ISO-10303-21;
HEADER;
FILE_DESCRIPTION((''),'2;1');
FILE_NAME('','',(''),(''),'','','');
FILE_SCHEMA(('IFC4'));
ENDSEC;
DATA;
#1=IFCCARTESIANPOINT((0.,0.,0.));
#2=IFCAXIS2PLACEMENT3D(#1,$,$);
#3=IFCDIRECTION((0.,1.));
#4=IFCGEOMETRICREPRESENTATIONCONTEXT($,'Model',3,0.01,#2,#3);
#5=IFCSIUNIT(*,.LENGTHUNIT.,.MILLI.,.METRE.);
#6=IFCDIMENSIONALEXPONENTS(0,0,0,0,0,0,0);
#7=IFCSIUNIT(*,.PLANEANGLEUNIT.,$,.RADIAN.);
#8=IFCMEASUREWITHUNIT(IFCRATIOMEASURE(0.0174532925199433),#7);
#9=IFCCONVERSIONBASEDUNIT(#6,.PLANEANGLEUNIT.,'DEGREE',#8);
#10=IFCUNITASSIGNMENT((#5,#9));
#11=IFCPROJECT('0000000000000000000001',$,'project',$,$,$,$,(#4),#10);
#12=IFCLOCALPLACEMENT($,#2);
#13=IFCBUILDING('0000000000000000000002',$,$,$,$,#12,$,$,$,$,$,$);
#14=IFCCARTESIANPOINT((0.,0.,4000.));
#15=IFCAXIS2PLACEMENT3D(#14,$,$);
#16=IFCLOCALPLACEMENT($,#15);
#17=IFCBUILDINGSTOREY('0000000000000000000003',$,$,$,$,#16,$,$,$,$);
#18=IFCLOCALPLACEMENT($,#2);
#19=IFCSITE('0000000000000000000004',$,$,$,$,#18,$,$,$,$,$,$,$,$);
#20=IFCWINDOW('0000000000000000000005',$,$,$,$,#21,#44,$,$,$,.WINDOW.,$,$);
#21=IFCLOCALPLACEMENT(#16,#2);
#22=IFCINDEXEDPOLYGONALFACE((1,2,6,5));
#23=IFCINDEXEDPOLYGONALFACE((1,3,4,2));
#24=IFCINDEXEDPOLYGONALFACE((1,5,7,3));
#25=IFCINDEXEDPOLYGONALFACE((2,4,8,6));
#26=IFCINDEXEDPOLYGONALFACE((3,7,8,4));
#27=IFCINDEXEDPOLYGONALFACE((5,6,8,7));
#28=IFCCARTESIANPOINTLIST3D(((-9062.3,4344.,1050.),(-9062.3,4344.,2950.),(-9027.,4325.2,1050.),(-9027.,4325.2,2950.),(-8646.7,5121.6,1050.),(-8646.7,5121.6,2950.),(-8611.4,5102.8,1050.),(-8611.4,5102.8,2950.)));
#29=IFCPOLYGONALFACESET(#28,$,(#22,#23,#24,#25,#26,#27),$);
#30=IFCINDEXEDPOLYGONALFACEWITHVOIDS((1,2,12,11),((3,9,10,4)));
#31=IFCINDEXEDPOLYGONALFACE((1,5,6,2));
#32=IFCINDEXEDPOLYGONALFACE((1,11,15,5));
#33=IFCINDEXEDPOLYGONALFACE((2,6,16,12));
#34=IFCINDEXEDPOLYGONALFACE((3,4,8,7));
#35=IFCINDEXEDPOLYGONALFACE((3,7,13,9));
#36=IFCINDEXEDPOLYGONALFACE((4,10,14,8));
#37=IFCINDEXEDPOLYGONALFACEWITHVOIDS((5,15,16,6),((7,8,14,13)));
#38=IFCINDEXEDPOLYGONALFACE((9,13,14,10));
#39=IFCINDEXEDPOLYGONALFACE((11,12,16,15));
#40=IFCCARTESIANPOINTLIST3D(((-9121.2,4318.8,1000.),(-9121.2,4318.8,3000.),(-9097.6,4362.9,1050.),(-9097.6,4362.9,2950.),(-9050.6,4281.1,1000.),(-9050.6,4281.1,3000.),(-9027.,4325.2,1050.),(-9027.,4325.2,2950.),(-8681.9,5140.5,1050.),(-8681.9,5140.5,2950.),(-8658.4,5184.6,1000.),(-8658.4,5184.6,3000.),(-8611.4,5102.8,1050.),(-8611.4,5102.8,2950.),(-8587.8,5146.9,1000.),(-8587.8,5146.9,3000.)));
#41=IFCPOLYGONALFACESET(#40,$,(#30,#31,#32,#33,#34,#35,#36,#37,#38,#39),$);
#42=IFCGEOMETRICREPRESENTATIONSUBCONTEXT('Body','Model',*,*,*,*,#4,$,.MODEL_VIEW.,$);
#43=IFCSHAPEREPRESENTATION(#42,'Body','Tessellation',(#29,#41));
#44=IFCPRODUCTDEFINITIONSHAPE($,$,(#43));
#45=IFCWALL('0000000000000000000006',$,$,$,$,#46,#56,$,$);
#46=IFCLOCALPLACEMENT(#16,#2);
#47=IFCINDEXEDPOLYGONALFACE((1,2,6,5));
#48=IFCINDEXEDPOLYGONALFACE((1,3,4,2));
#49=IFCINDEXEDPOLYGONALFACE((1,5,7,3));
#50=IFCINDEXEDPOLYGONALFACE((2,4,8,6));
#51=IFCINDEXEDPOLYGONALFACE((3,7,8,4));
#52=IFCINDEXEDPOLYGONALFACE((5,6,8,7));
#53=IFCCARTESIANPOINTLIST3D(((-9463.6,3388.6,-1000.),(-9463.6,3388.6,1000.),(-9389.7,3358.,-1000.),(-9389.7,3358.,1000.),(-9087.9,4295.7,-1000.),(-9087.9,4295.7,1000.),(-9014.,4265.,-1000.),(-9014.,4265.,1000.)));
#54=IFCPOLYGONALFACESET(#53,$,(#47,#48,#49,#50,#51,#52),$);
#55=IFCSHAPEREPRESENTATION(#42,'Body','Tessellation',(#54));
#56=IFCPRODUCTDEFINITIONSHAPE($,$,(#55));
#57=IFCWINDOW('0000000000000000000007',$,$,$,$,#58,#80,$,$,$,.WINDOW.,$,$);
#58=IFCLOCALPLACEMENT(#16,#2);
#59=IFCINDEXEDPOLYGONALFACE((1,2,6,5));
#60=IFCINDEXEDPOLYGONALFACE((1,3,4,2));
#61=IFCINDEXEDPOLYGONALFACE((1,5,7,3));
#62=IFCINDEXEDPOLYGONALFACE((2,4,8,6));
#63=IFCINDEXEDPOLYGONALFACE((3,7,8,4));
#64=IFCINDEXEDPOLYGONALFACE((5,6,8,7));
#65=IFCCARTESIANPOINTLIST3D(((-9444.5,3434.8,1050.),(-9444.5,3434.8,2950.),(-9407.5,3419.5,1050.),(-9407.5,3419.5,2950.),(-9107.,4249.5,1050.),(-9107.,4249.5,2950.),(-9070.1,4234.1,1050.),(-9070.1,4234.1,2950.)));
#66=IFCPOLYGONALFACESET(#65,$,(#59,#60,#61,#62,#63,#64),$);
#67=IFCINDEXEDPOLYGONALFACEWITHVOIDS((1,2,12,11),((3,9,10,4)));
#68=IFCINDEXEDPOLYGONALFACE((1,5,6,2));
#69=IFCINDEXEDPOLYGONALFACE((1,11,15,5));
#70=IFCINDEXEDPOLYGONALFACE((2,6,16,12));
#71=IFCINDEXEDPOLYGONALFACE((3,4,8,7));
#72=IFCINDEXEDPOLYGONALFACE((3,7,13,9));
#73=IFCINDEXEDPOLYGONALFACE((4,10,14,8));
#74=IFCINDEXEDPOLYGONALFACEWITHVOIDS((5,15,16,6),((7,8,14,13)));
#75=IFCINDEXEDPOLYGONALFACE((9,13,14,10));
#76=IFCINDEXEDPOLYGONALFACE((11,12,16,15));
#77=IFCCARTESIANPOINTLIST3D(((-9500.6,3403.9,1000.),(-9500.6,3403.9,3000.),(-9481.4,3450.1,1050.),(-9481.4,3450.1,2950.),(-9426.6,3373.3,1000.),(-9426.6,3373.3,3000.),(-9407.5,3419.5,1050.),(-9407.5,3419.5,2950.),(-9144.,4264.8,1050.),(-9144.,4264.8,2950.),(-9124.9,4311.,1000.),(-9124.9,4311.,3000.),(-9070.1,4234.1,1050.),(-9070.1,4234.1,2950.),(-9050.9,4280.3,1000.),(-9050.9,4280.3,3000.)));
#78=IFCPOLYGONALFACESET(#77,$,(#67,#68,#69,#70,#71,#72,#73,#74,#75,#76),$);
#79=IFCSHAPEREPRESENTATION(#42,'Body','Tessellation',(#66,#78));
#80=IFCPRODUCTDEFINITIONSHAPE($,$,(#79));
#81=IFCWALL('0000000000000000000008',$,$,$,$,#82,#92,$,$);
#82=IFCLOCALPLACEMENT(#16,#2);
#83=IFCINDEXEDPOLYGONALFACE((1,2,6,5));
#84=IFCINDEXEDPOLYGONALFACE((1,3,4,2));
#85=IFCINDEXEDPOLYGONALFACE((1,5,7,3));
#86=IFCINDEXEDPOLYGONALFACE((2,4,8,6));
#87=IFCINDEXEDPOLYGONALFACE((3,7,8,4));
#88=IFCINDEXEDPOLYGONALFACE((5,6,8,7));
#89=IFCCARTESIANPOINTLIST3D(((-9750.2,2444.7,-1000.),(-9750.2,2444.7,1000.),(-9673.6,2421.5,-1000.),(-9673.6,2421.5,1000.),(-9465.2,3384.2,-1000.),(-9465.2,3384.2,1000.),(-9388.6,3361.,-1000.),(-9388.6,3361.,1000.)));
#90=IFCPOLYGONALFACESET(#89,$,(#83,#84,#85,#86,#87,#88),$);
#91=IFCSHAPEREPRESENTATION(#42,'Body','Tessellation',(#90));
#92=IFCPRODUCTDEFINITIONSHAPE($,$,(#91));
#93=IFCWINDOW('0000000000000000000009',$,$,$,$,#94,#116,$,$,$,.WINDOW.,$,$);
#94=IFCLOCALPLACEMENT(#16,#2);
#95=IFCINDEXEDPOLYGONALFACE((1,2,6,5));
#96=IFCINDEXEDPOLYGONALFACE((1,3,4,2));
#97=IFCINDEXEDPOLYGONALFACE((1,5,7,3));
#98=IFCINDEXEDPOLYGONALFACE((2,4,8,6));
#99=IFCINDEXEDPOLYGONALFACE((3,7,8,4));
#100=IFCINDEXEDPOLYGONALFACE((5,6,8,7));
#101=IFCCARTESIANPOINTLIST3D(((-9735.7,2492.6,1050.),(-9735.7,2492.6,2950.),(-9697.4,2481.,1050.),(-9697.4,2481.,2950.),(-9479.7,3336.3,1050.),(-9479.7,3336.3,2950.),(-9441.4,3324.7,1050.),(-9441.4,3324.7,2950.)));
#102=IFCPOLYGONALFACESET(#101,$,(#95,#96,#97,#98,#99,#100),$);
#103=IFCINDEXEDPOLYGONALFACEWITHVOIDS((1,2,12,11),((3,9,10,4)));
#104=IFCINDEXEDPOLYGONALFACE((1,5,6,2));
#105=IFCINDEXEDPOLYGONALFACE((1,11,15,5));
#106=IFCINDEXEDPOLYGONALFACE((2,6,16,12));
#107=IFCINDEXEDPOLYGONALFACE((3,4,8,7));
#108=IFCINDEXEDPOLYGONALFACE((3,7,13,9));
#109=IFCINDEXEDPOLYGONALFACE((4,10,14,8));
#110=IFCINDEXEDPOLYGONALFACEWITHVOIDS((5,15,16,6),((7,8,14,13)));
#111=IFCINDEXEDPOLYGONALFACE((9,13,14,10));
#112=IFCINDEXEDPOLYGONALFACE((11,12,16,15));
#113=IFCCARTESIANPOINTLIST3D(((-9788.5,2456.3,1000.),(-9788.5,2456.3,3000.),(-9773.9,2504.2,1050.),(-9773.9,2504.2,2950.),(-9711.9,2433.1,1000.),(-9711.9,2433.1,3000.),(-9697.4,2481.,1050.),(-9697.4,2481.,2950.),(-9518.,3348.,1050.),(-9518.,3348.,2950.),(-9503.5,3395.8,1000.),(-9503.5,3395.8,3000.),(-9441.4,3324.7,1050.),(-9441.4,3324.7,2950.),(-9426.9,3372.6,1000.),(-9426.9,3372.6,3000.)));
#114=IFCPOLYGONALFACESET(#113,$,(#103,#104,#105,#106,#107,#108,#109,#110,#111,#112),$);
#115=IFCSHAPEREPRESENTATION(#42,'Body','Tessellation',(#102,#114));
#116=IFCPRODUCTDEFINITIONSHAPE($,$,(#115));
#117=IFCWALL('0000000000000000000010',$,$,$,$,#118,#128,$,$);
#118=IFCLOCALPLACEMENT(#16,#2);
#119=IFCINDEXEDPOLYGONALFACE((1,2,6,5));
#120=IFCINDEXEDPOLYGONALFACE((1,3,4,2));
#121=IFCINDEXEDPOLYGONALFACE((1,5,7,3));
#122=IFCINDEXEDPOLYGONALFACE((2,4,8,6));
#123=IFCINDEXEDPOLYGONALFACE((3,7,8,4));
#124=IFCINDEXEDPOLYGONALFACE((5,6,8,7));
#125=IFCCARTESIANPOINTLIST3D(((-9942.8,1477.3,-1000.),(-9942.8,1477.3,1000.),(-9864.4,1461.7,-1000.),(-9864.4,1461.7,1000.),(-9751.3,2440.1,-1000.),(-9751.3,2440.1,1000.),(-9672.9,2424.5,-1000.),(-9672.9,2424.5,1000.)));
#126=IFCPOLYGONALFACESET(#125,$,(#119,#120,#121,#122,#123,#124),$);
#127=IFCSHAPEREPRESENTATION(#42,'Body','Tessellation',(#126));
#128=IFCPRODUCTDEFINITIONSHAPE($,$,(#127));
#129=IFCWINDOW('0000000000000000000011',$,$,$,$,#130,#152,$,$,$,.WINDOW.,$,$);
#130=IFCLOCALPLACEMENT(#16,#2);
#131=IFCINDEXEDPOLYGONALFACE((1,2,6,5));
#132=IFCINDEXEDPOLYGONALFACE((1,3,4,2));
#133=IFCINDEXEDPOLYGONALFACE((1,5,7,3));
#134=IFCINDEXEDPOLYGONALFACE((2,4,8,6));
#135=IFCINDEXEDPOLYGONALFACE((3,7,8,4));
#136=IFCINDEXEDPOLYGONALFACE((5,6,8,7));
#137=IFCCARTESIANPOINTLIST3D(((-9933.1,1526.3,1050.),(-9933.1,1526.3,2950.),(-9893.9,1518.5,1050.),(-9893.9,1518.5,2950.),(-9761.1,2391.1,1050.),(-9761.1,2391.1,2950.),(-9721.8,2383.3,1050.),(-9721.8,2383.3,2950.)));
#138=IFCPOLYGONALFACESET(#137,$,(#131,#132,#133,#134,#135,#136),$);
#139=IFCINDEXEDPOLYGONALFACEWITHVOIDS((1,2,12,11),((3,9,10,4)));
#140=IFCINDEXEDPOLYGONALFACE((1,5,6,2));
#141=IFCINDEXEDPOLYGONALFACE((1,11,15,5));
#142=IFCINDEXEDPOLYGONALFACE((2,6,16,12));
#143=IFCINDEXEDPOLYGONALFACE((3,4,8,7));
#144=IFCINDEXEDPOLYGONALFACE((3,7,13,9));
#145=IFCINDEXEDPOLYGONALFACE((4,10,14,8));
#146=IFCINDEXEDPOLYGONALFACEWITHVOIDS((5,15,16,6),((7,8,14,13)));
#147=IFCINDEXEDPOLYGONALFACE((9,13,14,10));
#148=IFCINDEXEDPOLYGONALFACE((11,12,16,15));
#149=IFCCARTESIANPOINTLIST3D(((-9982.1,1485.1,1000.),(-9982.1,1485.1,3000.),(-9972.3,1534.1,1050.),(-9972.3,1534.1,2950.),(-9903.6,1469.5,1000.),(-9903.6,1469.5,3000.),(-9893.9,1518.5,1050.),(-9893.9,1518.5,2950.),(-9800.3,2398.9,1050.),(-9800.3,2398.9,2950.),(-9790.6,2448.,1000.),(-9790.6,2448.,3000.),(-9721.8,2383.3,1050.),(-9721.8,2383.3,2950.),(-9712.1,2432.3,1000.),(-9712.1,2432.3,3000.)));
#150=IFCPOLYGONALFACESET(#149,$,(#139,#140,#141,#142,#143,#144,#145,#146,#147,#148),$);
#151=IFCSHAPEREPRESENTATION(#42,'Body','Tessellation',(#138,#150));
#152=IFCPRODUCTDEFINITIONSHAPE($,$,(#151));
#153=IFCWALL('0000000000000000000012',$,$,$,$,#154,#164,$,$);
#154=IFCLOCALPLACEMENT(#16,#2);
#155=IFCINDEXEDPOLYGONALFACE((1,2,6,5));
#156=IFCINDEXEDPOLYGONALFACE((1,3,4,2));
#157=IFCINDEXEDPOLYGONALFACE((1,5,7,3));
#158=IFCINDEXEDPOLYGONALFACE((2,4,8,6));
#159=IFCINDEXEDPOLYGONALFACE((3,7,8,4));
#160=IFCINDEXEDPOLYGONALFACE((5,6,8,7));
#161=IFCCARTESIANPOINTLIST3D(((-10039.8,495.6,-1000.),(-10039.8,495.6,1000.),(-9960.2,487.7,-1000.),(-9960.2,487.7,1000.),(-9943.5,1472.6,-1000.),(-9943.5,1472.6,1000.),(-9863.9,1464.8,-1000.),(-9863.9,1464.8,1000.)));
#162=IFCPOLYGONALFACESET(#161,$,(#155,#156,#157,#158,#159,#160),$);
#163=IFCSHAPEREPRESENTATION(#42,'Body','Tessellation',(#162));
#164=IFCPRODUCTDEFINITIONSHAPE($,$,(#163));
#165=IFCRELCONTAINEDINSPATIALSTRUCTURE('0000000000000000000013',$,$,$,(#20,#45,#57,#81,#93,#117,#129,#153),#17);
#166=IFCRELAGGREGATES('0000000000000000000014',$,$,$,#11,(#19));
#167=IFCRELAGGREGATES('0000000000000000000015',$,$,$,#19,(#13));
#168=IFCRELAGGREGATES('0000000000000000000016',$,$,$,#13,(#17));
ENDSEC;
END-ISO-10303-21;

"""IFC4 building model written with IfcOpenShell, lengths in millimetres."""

from ifc_helpers import new_model, entity, si_unit, converted_unit, direction, frame, origin, origin_2d, place, context, subcontext, project, spatial, rectangle, extrude, element, save


model = new_model("IFC4")

# Units and contexts
model_context = context("Model", 3, precision=0.01, world=origin(), true_north=direction((0.0, 1.0)))
body_context = subcontext(model_context, "Body", "Model", "MODEL_VIEW")
ifc_project = project(units=[si_unit("LENGTHUNIT", "METRE", prefix="MILLI"), converted_unit("PLANEANGLEUNIT", "DEGREE", entity("IfcRatioMeasure", 0.0174532925199433), si_unit("PLANEANGLEUNIT", "RADIAN"), dimensions=[0, 0, 0, 0, 0, 0, 0])], contexts=[model_context])

# Site, building, storey
site_placement = place(None, origin())
site = spatial("IfcSite", under=ifc_project, at=site_placement)
building_placement = place(None, origin())
building = spatial("IfcBuilding", under=site, at=building_placement)
storey_placement = place(None, frame((0.0, 0.0, 4000.0)))
storey = spatial("IfcBuildingStorey", under=building, at=storey_placement)

# Shared definitions
cartesian_point_1 = entity("IfcCartesianPoint", [-440.9, -950.0])
shared_polyline = entity("IfcPolyline", [cartesian_point_1, entity("IfcCartesianPoint", [-440.9, 950.0]), entity("IfcCartesianPoint", [-440.9, 950.0]), entity("IfcCartesianPoint", [440.9, 950.0]), entity("IfcCartesianPoint", [440.9, 950.0]), entity("IfcCartesianPoint", [440.9, -950.0]), entity("IfcCartesianPoint", [440.9, -950.0]), entity("IfcCartesianPoint", [-440.9, -950.0]), cartesian_point_1])

# Window
window_1_placement = place(storey_placement, frame((-8819.2, 4714.0, 2000.0), z_axis=(0.0, 0.0, 1.0), x_axis=(-4713.96836, -8819.212113, 0.0)))
cartesian_point_2 = entity("IfcCartesianPoint", [-490.9, -1000.0])
element("IfcWindow", 1, at=window_1_placement, inside=storey, PredefinedType="WINDOW", context=body_context, shape_type="SweptSolid", body=[
    entity("IfcExtrudedAreaSolid", entity("IfcArbitraryClosedProfileDef", "AREA", None, shared_polyline), entity("IfcAxis2Placement3D", entity("IfcCartesianPoint", [0.0, 0.0, 0.0]), entity("IfcDirection", [0.0, -1.0, 0.0]), entity("IfcDirection", [1.0, 0.0, 0.0])), entity("IfcDirection", [0.0, 0.0, 1.0]), 40.0),
    entity("IfcExtrudedAreaSolid", entity("IfcArbitraryProfileDefWithVoids", "AREA", None, entity("IfcPolyline", [cartesian_point_2, entity("IfcCartesianPoint", [-490.9, 1000.0]), entity("IfcCartesianPoint", [-490.9, 1000.0]), entity("IfcCartesianPoint", [490.9, 1000.0]), entity("IfcCartesianPoint", [490.9, 1000.0]), entity("IfcCartesianPoint", [490.9, -1000.0]), entity("IfcCartesianPoint", [490.9, -1000.0]), entity("IfcCartesianPoint", [-490.9, -1000.0]), cartesian_point_2]), [shared_polyline]), entity("IfcAxis2Placement3D", entity("IfcCartesianPoint", [0.0, 0.0, 0.0]), entity("IfcDirection", [0.0, -1.0, 0.0]), entity("IfcDirection", [1.0, 0.0, 0.0])), entity("IfcDirection", [0.0, 0.0, 1.0]), 80.0),
])

# Wall
wall_1_placement = place(storey_placement, frame((-9238.8, 3826.8, -1000.0), z_axis=(0.0, 0.0, 1.0), x_axis=(-3826.834994, -9238.795048, 0.0)))
element("IfcWall", 2, at=wall_1_placement, inside=storey, context=body_context, shape_type="SweptSolid", body=[
    extrude(rectangle(XDim=981.7, YDim=80.0, at=origin_2d()), origin(), (0.0, 0.0, 1.0), 2000.0),
])

# Window
window_2_placement = place(storey_placement, frame((-9238.8, 3826.8, 2000.0), z_axis=(0.0, 0.0, 1.0), x_axis=(-3826.834994, -9238.795048, 0.0)))
cartesian_point_3 = entity("IfcCartesianPoint", [-490.9, -1000.0])
element("IfcWindow", 3, at=window_2_placement, inside=storey, PredefinedType="WINDOW", context=body_context, shape_type="SweptSolid", body=[
    entity("IfcExtrudedAreaSolid", entity("IfcArbitraryClosedProfileDef", "AREA", None, shared_polyline), entity("IfcAxis2Placement3D", entity("IfcCartesianPoint", [0.0, 0.0, 0.0]), entity("IfcDirection", [0.0, -1.0, 0.0]), entity("IfcDirection", [1.0, 0.0, 0.0])), entity("IfcDirection", [0.0, 0.0, 1.0]), 40.0),
    entity("IfcExtrudedAreaSolid", entity("IfcArbitraryProfileDefWithVoids", "AREA", None, entity("IfcPolyline", [cartesian_point_3, entity("IfcCartesianPoint", [-490.9, 1000.0]), entity("IfcCartesianPoint", [-490.9, 1000.0]), entity("IfcCartesianPoint", [490.9, 1000.0]), entity("IfcCartesianPoint", [490.9, 1000.0]), entity("IfcCartesianPoint", [490.9, -1000.0]), entity("IfcCartesianPoint", [490.9, -1000.0]), entity("IfcCartesianPoint", [-490.9, -1000.0]), cartesian_point_3]), [shared_polyline]), entity("IfcAxis2Placement3D", entity("IfcCartesianPoint", [0.0, 0.0, 0.0]), entity("IfcDirection", [0.0, -1.0, 0.0]), entity("IfcDirection", [1.0, 0.0, 0.0])), entity("IfcDirection", [0.0, 0.0, 1.0]), 80.0),
])

# Wall
wall_2_placement = place(storey_placement, frame((-9569.4, 2902.8, -1000.0), z_axis=(0.0, 0.0, 1.0), x_axis=(-2902.847084, -9569.403263, 0.0)))
element("IfcWall", 4, at=wall_2_placement, inside=storey, context=body_context, shape_type="SweptSolid", body=[
    extrude(rectangle(XDim=981.7, YDim=80.0, at=origin_2d()), origin(), (0.0, 0.0, 1.0), 2000.0),
])

# Window
window_3_placement = place(storey_placement, frame((-9569.4, 2902.8, 2000.0), z_axis=(0.0, 0.0, 1.0), x_axis=(-2902.847084, -9569.403263, 0.0)))
cartesian_point_4 = entity("IfcCartesianPoint", [-490.9, -1000.0])
element("IfcWindow", 5, at=window_3_placement, inside=storey, PredefinedType="WINDOW", context=body_context, shape_type="SweptSolid", body=[
    entity("IfcExtrudedAreaSolid", entity("IfcArbitraryClosedProfileDef", "AREA", None, shared_polyline), entity("IfcAxis2Placement3D", entity("IfcCartesianPoint", [0.0, 0.0, 0.0]), entity("IfcDirection", [0.0, -1.0, 0.0]), entity("IfcDirection", [1.0, 0.0, 0.0])), entity("IfcDirection", [0.0, 0.0, 1.0]), 40.0),
    entity("IfcExtrudedAreaSolid", entity("IfcArbitraryProfileDefWithVoids", "AREA", None, entity("IfcPolyline", [cartesian_point_4, entity("IfcCartesianPoint", [-490.9, 1000.0]), entity("IfcCartesianPoint", [-490.9, 1000.0]), entity("IfcCartesianPoint", [490.9, 1000.0]), entity("IfcCartesianPoint", [490.9, 1000.0]), entity("IfcCartesianPoint", [490.9, -1000.0]), entity("IfcCartesianPoint", [490.9, -1000.0]), entity("IfcCartesianPoint", [-490.9, -1000.0]), cartesian_point_4]), [shared_polyline]), entity("IfcAxis2Placement3D", entity("IfcCartesianPoint", [0.0, 0.0, 0.0]), entity("IfcDirection", [0.0, -1.0, 0.0]), entity("IfcDirection", [1.0, 0.0, 0.0])), entity("IfcDirection", [0.0, 0.0, 1.0]), 80.0),
])

# Wall
wall_3_placement = place(storey_placement, frame((-9807.9, 1950.9, -1000.0), z_axis=(0.0, 0.0, 1.0), x_axis=(-1950.903147, -9807.852819, 0.0)))
element("IfcWall", 6, at=wall_3_placement, inside=storey, context=body_context, shape_type="SweptSolid", body=[
    extrude(rectangle(XDim=981.7, YDim=80.0, at=origin_2d()), origin(), (0.0, 0.0, 1.0), 2000.0),
])

# Window
window_4_placement = place(storey_placement, frame((-9807.9, 1950.9, 2000.0), z_axis=(0.0, 0.0, 1.0), x_axis=(-1950.903147, -9807.852819, 0.0)))
cartesian_point_5 = entity("IfcCartesianPoint", [-490.9, -1000.0])
element("IfcWindow", 7, at=window_4_placement, inside=storey, PredefinedType="WINDOW", context=body_context, shape_type="SweptSolid", body=[
    entity("IfcExtrudedAreaSolid", entity("IfcArbitraryClosedProfileDef", "AREA", None, shared_polyline), entity("IfcAxis2Placement3D", entity("IfcCartesianPoint", [0.0, 0.0, 0.0]), entity("IfcDirection", [0.0, -1.0, 0.0]), entity("IfcDirection", [1.0, 0.0, 0.0])), entity("IfcDirection", [0.0, 0.0, 1.0]), 40.0),
    entity("IfcExtrudedAreaSolid", entity("IfcArbitraryProfileDefWithVoids", "AREA", None, entity("IfcPolyline", [cartesian_point_5, entity("IfcCartesianPoint", [-490.9, 1000.0]), entity("IfcCartesianPoint", [-490.9, 1000.0]), entity("IfcCartesianPoint", [490.9, 1000.0]), entity("IfcCartesianPoint", [490.9, 1000.0]), entity("IfcCartesianPoint", [490.9, -1000.0]), entity("IfcCartesianPoint", [490.9, -1000.0]), entity("IfcCartesianPoint", [-490.9, -1000.0]), cartesian_point_5]), [shared_polyline]), entity("IfcAxis2Placement3D", entity("IfcCartesianPoint", [0.0, 0.0, 0.0]), entity("IfcDirection", [0.0, -1.0, 0.0]), entity("IfcDirection", [1.0, 0.0, 0.0])), entity("IfcDirection", [0.0, 0.0, 1.0]), 80.0),
])

# Wall
wall_4_placement = place(storey_placement, frame((-9951.8, 980.2, -1000.0), z_axis=(0.0, 0.0, 1.0), x_axis=(-980.170931, -9951.847313, 0.0)))
element("IfcWall", 8, at=wall_4_placement, inside=storey, context=body_context, shape_type="SweptSolid", body=[
    extrude(rectangle(XDim=981.7, YDim=80.0, at=origin_2d()), origin(), (0.0, 0.0, 1.0), 2000.0),
])

save(model, "model.ifc")
